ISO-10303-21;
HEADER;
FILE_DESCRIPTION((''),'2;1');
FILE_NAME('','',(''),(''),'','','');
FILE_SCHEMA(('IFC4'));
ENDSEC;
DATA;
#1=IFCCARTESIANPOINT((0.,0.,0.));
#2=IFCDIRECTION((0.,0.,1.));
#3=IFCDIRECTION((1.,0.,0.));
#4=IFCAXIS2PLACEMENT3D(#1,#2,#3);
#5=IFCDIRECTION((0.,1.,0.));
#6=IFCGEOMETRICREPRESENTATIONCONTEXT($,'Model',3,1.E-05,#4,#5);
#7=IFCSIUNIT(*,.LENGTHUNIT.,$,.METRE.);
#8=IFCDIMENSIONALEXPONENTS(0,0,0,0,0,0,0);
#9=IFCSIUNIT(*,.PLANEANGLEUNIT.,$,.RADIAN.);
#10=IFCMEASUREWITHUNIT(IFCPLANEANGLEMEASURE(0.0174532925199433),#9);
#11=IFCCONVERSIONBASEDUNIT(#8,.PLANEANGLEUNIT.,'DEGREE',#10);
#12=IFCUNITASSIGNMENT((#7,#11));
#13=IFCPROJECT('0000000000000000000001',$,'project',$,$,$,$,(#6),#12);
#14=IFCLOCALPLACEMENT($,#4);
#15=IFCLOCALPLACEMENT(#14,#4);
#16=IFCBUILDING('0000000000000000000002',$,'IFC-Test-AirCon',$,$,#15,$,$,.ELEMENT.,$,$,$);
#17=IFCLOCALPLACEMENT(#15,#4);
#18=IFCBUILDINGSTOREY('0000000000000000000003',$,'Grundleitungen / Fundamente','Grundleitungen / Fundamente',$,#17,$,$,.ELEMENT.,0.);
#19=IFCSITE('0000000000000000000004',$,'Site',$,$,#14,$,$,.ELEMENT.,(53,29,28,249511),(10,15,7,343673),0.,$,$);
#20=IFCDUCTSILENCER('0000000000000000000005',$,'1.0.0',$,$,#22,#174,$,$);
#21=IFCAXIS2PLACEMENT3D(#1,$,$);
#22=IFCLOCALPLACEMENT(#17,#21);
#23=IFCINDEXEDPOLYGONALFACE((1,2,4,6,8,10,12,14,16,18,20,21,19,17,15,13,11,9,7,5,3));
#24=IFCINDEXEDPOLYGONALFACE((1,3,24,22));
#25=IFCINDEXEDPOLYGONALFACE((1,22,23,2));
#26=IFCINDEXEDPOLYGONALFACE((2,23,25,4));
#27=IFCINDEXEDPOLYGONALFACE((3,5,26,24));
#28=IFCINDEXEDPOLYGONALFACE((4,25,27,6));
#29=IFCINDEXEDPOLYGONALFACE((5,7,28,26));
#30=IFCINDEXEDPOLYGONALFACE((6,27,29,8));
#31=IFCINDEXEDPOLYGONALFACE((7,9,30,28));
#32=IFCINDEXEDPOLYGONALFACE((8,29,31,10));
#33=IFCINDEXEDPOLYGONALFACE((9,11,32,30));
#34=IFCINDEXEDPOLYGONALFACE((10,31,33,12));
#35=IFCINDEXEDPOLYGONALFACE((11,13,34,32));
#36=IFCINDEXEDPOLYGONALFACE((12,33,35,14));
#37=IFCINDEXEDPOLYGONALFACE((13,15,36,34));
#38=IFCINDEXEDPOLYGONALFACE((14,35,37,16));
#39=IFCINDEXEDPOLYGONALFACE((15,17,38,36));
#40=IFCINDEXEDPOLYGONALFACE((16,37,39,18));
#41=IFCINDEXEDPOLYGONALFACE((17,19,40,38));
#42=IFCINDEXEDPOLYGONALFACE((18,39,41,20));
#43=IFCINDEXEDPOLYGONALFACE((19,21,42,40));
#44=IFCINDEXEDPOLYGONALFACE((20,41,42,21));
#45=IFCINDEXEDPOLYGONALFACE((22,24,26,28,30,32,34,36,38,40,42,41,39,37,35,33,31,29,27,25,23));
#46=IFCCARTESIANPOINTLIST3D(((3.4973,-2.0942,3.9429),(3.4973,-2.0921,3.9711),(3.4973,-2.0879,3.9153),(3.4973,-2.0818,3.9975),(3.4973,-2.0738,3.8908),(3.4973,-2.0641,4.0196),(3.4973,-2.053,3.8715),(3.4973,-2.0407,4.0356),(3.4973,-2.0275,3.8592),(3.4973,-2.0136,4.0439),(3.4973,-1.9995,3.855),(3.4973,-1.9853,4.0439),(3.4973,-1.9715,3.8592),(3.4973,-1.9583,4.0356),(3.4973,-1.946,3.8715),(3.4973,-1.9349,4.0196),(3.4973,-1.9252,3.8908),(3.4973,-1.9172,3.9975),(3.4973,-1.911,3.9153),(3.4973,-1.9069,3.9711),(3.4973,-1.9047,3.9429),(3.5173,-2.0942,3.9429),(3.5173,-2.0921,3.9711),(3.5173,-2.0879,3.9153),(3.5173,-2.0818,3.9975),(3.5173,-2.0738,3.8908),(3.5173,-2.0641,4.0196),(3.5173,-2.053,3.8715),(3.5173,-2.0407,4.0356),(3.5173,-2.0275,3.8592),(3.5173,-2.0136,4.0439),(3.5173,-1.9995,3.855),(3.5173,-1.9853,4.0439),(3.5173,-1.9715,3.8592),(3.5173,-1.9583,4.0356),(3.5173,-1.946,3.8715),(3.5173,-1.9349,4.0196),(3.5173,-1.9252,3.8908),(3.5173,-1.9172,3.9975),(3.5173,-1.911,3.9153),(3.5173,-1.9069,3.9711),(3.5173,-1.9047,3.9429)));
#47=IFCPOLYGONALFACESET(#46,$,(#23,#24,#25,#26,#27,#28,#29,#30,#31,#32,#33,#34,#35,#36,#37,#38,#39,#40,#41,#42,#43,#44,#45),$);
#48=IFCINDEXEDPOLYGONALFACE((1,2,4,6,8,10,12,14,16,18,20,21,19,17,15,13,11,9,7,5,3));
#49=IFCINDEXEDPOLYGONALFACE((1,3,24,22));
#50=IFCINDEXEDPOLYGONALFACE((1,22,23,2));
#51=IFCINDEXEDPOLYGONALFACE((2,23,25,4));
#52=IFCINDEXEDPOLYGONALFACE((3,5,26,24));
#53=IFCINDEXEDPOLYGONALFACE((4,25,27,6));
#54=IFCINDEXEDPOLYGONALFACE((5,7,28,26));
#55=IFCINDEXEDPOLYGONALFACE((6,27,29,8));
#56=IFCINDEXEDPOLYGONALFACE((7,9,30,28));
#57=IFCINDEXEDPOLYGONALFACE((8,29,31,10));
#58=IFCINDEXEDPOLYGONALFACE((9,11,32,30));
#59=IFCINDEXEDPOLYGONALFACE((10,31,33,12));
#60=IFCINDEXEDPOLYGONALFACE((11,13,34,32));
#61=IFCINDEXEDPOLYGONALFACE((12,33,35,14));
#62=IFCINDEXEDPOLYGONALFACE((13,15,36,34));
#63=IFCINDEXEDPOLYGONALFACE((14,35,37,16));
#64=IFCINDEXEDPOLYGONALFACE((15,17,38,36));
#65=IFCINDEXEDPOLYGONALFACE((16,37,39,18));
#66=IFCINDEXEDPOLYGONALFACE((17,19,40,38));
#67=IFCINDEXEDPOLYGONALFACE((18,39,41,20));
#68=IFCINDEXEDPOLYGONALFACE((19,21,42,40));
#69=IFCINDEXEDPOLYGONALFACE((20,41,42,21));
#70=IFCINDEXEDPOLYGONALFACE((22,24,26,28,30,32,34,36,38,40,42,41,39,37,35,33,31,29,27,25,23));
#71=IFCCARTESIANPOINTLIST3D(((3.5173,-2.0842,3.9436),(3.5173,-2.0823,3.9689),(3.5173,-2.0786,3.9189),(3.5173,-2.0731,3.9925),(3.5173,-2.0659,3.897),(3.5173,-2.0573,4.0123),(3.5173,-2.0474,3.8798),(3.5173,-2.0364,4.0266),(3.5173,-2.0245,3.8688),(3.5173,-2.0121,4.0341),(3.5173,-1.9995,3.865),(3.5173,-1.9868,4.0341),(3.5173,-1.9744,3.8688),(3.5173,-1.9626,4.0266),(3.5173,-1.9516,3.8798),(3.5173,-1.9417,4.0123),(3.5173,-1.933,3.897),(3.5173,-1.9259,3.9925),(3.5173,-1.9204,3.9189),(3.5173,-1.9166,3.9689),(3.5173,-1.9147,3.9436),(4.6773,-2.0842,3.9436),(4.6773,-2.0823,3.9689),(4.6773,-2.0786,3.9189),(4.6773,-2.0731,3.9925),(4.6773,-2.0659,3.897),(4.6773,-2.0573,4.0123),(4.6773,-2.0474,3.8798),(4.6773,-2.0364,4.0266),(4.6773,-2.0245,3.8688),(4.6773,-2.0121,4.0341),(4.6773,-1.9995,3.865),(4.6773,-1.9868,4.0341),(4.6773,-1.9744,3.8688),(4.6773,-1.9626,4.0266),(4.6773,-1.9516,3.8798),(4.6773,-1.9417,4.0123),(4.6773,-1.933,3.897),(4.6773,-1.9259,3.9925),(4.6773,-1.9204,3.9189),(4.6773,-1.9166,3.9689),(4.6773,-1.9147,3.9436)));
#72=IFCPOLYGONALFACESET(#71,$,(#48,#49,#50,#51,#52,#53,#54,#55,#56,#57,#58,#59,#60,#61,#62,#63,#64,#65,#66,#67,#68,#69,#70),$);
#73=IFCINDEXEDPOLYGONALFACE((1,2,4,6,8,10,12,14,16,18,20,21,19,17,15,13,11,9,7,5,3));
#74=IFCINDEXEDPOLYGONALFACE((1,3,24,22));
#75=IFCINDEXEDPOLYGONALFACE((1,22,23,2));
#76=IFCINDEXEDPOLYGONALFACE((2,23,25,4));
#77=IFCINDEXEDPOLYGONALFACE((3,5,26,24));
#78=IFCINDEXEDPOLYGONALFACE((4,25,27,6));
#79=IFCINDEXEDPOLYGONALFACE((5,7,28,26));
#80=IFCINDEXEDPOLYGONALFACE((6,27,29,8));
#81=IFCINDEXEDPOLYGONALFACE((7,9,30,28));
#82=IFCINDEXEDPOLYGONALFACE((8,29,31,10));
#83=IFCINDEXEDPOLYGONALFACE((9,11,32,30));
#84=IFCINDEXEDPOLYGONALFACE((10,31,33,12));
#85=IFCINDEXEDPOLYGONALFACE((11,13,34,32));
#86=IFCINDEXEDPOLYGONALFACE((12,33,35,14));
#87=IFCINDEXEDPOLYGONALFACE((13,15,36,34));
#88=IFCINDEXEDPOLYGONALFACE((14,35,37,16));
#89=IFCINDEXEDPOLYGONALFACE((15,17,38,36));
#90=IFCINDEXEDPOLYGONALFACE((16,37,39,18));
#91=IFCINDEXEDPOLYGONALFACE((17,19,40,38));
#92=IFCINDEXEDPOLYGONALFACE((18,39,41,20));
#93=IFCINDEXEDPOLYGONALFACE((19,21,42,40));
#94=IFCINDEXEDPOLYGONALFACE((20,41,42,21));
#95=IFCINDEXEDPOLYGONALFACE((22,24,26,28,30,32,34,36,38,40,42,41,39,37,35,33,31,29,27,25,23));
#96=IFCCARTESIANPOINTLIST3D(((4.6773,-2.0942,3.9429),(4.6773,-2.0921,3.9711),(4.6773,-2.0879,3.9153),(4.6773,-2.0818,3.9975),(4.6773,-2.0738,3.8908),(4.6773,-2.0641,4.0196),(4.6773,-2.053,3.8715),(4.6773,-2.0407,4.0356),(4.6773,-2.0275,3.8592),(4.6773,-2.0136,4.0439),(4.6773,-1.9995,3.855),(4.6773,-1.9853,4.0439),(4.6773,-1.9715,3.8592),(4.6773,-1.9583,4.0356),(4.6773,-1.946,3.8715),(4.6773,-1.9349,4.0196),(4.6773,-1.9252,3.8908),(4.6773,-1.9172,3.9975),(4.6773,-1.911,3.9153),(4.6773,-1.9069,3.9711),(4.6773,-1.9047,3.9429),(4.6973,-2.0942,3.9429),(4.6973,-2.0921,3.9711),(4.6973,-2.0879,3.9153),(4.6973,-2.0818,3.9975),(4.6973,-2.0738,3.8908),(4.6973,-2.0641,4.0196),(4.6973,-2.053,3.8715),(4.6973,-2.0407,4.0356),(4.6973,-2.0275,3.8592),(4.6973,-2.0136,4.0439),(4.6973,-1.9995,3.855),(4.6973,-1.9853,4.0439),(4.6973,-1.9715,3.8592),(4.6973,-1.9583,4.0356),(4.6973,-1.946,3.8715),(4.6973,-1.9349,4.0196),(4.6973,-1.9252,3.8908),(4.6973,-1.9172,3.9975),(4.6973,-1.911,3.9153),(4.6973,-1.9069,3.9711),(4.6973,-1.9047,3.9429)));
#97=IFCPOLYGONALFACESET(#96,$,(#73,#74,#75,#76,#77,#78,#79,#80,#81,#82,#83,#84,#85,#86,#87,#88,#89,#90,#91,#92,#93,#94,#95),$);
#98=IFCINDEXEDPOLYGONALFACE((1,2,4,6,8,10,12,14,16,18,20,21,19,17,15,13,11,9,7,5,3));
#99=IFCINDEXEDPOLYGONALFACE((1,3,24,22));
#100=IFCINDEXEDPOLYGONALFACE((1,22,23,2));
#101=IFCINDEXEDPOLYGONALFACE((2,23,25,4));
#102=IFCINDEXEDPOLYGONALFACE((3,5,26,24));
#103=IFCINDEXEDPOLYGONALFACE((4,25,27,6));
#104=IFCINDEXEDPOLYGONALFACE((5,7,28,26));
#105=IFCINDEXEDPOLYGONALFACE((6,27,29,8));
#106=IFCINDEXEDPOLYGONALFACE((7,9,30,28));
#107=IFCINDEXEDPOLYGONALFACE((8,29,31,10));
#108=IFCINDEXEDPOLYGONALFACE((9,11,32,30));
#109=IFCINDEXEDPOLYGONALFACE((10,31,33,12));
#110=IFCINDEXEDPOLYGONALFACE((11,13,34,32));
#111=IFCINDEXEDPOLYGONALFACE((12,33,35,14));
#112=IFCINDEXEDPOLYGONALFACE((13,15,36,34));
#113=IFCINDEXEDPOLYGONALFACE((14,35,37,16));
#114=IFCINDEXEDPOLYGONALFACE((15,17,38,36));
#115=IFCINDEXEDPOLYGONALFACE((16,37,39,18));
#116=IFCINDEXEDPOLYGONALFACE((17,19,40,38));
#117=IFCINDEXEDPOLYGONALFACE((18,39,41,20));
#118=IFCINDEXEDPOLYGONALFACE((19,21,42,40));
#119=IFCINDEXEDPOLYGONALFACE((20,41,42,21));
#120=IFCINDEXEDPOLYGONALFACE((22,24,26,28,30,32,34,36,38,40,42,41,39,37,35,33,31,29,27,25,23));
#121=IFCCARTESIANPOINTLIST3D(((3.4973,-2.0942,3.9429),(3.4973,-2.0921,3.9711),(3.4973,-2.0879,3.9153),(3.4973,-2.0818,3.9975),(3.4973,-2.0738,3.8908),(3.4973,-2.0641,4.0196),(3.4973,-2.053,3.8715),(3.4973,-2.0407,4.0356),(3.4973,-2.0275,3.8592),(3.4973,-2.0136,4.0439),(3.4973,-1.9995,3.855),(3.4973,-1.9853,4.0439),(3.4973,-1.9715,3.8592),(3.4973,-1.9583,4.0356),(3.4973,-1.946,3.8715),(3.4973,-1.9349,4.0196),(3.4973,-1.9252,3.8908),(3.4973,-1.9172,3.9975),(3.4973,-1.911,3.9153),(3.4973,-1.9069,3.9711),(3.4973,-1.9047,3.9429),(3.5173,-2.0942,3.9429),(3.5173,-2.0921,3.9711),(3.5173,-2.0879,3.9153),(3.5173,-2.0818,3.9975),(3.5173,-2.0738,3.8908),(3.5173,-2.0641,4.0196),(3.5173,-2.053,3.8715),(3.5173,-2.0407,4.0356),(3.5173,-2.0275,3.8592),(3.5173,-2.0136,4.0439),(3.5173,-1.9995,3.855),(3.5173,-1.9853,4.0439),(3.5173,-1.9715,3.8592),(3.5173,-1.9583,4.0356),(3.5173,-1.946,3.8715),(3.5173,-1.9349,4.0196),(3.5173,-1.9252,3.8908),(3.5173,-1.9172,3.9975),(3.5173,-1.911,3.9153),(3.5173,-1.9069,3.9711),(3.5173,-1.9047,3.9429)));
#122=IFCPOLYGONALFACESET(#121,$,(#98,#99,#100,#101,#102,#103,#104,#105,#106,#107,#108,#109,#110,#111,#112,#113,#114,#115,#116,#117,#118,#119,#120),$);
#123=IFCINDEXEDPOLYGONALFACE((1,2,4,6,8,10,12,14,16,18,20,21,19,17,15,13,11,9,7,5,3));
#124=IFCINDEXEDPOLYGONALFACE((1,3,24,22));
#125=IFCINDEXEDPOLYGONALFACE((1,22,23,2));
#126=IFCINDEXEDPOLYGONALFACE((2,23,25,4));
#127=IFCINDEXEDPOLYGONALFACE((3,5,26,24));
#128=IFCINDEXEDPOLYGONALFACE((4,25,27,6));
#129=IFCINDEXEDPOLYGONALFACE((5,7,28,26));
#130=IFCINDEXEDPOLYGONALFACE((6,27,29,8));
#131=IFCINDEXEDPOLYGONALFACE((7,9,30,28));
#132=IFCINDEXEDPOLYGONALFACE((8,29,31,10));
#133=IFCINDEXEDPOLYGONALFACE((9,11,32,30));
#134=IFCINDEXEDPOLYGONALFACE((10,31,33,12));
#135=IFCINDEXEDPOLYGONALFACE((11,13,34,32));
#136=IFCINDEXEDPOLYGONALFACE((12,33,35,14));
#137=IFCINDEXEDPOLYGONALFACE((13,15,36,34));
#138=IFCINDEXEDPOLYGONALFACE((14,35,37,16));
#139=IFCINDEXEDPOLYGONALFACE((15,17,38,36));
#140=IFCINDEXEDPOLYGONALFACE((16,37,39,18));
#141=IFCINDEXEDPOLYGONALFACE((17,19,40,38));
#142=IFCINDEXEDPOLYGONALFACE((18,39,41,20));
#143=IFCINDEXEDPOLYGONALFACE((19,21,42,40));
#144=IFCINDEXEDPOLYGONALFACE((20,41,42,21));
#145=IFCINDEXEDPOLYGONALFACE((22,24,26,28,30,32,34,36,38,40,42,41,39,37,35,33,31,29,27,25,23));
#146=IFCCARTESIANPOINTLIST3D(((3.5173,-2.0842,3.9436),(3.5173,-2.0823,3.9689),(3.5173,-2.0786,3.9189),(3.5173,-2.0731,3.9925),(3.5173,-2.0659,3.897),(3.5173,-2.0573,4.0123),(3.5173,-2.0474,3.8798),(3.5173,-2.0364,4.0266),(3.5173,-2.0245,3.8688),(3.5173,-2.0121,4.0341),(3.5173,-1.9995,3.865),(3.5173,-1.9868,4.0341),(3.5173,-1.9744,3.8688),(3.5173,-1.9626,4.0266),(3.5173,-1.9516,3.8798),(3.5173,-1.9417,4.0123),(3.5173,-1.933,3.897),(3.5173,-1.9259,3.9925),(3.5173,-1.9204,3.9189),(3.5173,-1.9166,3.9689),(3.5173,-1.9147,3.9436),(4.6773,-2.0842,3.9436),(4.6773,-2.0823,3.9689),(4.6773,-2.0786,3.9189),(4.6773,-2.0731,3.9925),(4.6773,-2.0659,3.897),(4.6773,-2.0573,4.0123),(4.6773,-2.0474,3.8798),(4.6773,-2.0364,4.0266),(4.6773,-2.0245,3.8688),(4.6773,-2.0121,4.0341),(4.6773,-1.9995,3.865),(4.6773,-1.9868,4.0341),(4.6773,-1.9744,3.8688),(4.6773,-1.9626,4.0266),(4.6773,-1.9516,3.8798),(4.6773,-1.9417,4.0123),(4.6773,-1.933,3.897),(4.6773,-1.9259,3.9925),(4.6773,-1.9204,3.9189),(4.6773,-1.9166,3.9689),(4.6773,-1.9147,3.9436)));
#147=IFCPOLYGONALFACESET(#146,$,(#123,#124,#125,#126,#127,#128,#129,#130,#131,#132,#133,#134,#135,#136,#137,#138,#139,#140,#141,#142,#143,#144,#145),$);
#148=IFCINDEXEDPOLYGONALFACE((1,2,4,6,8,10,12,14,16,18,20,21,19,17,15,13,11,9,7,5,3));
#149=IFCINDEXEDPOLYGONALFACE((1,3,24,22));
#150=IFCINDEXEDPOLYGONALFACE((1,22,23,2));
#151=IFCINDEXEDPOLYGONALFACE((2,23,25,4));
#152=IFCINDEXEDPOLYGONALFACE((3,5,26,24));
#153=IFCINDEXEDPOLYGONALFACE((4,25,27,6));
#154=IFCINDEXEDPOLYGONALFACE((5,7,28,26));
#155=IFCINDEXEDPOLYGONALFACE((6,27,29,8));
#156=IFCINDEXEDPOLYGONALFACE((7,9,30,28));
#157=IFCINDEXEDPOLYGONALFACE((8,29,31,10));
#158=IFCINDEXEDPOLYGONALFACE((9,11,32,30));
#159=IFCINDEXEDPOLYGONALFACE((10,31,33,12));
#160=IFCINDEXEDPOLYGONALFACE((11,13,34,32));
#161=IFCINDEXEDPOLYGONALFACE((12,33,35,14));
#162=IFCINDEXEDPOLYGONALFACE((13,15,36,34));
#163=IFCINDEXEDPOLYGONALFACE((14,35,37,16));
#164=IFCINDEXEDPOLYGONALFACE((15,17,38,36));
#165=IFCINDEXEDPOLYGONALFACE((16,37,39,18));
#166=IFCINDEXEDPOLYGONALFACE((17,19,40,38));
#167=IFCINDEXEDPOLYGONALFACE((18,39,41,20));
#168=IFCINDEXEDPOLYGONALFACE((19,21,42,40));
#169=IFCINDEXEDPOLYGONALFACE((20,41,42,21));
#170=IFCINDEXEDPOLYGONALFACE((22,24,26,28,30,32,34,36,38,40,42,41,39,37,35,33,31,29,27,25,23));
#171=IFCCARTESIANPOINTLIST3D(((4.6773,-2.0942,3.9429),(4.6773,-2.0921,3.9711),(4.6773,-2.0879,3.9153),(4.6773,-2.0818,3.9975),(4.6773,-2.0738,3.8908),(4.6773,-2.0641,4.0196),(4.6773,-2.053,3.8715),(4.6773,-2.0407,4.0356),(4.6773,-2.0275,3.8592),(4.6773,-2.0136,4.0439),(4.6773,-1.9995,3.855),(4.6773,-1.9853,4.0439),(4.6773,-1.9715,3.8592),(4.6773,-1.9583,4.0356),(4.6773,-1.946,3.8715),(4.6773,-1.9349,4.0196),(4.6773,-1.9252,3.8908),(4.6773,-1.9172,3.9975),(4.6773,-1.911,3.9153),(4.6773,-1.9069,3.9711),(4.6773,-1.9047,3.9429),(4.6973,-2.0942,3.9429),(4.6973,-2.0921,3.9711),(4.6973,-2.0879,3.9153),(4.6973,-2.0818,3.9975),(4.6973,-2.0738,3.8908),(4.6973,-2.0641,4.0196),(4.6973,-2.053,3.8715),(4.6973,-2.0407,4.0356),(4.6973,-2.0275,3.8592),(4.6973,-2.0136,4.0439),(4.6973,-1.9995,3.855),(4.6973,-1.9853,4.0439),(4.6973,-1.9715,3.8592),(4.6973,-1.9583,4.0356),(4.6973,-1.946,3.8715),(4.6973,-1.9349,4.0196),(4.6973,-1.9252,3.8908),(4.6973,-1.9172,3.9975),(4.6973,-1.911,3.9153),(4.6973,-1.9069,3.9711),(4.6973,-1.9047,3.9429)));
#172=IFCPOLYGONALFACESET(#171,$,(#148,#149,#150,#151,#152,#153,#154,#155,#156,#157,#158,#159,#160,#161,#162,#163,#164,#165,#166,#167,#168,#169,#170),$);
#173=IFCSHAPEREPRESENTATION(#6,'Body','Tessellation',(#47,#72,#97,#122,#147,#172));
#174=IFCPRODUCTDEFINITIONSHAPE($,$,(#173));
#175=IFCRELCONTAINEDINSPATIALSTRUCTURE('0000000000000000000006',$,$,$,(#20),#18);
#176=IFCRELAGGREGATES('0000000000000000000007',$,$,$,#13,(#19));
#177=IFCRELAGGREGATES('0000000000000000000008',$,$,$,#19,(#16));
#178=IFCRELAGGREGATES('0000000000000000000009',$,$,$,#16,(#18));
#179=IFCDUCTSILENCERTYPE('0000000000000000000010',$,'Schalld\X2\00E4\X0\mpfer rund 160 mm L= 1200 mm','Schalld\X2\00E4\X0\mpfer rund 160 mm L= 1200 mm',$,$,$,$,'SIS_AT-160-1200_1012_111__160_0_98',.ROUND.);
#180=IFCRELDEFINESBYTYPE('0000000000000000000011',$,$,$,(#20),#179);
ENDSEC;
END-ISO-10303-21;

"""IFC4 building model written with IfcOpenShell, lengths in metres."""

from ifc_helpers import new_model, entity, si_unit, converted_unit, direction, frame, origin_with_axes, origin_2d_with_axis, place, context, subcontext, project, spatial, circle, extrude, source, transform, mapped, type_object, element, save


model = new_model("IFC4")

# Units and contexts
model_context = context("Model", 3, precision=1e-05, world=origin_with_axes(), true_north=direction((0.0, 1.0, 0.0)))
body_context = subcontext(model_context, "Body", "Model", "MODEL_VIEW")
ifc_project = project(units=[si_unit("LENGTHUNIT", "METRE"), converted_unit("PLANEANGLEUNIT", "DEGREE", entity("IfcPlaneAngleMeasure", 0.0174532925199433), si_unit("PLANEANGLEUNIT", "RADIAN"), dimensions=[0, 0, 0, 0, 0, 0, 0])], contexts=[model_context])

# Site, building, storey
site_placement = place(None, origin_with_axes())
site = spatial("IfcSite", under=ifc_project, at=site_placement, Name="Site", CompositionType="ELEMENT", RefLatitude=(53, 29, 28, 249511), RefLongitude=(10, 15, 7, 343673), RefElevation=0.0)
building_placement = place(site_placement, origin_with_axes())
building = spatial("IfcBuilding", under=site, at=building_placement, Name="IFC-Test-AirCon", CompositionType="ELEMENT")
storey_placement = place(building_placement, origin_with_axes())
storey = spatial("IfcBuildingStorey", under=building, at=storey_placement, Name="Grundleitungen / Fundamente", Description="Grundleitungen / Fundamente", CompositionType="ELEMENT", Elevation=0.0)

# Duct silencer
duct_silencer_type = type_object("IfcDuctSilencerType", Name="Schalldämpfer rund 160 mm L= 1200 mm", Description="Schalldämpfer rund 160 mm L= 1200 mm", ElementType="SIS_AT-160-1200_1012_111__160_0_98", PredefinedType="ROUND")
shared_shape_1 = source(origin_with_axes(), body_context, "Body", "SweptSolid", [
    extrude(circle(Radius=0.095, at=origin_2d_with_axis()), frame((-0.6, 0.0, 0.0), z_axis=(1.0, 0.0, 0.0), x_axis=(0.0, 0.0, -1.0)), (0.0, 0.0, 1.0), 0.02),
    extrude(circle(Radius=0.085, at=origin_2d_with_axis()), frame((-0.58, 0.0, 0.0), z_axis=(1.0, 0.0, 0.0), x_axis=(0.0, 0.0, -1.0)), (0.0, 0.0, 1.0), 1.16),
    extrude(circle(Radius=0.095, at=origin_2d_with_axis()), frame((0.58, 0.0, 0.0), z_axis=(1.0, 0.0, 0.0), x_axis=(0.0, 0.0, -1.0)), (0.0, 0.0, 1.0), 0.02),
    extrude(circle(Radius=0.095, at=origin_2d_with_axis()), frame((-0.6, 0.0, 0.0), z_axis=(1.0, 0.0, 0.0), x_axis=(0.0, 0.0, -1.0)), (0.0, 0.0, 1.0), 0.02),
    extrude(circle(Radius=0.085, at=origin_2d_with_axis()), frame((-0.58, 0.0, 0.0), z_axis=(1.0, 0.0, 0.0), x_axis=(0.0, 0.0, -1.0)), (0.0, 0.0, 1.0), 1.16),
    extrude(circle(Radius=0.095, at=origin_2d_with_axis()), frame((0.58, 0.0, 0.0), z_axis=(1.0, 0.0, 0.0), x_axis=(0.0, 0.0, -1.0)), (0.0, 0.0, 1.0), 0.02),
])
duct_silencer_placement = place(storey_placement, frame((4.0973, -1.9995, 3.95), z_axis=(0.0, 0.0, 1.0), x_axis=(1.0, 0.0, 0.0)))
element("IfcDuctSilencer", 1, at=duct_silencer_placement, inside=storey, type_object=duct_silencer_type, Name="1.0.0", context=model_context, shape_type="MappedRepresentation", body=[
    mapped(shared_shape_1, transform((0.0, 0.0, 0.0), scale=1.0)),
])

save(model, "model.ifc")
